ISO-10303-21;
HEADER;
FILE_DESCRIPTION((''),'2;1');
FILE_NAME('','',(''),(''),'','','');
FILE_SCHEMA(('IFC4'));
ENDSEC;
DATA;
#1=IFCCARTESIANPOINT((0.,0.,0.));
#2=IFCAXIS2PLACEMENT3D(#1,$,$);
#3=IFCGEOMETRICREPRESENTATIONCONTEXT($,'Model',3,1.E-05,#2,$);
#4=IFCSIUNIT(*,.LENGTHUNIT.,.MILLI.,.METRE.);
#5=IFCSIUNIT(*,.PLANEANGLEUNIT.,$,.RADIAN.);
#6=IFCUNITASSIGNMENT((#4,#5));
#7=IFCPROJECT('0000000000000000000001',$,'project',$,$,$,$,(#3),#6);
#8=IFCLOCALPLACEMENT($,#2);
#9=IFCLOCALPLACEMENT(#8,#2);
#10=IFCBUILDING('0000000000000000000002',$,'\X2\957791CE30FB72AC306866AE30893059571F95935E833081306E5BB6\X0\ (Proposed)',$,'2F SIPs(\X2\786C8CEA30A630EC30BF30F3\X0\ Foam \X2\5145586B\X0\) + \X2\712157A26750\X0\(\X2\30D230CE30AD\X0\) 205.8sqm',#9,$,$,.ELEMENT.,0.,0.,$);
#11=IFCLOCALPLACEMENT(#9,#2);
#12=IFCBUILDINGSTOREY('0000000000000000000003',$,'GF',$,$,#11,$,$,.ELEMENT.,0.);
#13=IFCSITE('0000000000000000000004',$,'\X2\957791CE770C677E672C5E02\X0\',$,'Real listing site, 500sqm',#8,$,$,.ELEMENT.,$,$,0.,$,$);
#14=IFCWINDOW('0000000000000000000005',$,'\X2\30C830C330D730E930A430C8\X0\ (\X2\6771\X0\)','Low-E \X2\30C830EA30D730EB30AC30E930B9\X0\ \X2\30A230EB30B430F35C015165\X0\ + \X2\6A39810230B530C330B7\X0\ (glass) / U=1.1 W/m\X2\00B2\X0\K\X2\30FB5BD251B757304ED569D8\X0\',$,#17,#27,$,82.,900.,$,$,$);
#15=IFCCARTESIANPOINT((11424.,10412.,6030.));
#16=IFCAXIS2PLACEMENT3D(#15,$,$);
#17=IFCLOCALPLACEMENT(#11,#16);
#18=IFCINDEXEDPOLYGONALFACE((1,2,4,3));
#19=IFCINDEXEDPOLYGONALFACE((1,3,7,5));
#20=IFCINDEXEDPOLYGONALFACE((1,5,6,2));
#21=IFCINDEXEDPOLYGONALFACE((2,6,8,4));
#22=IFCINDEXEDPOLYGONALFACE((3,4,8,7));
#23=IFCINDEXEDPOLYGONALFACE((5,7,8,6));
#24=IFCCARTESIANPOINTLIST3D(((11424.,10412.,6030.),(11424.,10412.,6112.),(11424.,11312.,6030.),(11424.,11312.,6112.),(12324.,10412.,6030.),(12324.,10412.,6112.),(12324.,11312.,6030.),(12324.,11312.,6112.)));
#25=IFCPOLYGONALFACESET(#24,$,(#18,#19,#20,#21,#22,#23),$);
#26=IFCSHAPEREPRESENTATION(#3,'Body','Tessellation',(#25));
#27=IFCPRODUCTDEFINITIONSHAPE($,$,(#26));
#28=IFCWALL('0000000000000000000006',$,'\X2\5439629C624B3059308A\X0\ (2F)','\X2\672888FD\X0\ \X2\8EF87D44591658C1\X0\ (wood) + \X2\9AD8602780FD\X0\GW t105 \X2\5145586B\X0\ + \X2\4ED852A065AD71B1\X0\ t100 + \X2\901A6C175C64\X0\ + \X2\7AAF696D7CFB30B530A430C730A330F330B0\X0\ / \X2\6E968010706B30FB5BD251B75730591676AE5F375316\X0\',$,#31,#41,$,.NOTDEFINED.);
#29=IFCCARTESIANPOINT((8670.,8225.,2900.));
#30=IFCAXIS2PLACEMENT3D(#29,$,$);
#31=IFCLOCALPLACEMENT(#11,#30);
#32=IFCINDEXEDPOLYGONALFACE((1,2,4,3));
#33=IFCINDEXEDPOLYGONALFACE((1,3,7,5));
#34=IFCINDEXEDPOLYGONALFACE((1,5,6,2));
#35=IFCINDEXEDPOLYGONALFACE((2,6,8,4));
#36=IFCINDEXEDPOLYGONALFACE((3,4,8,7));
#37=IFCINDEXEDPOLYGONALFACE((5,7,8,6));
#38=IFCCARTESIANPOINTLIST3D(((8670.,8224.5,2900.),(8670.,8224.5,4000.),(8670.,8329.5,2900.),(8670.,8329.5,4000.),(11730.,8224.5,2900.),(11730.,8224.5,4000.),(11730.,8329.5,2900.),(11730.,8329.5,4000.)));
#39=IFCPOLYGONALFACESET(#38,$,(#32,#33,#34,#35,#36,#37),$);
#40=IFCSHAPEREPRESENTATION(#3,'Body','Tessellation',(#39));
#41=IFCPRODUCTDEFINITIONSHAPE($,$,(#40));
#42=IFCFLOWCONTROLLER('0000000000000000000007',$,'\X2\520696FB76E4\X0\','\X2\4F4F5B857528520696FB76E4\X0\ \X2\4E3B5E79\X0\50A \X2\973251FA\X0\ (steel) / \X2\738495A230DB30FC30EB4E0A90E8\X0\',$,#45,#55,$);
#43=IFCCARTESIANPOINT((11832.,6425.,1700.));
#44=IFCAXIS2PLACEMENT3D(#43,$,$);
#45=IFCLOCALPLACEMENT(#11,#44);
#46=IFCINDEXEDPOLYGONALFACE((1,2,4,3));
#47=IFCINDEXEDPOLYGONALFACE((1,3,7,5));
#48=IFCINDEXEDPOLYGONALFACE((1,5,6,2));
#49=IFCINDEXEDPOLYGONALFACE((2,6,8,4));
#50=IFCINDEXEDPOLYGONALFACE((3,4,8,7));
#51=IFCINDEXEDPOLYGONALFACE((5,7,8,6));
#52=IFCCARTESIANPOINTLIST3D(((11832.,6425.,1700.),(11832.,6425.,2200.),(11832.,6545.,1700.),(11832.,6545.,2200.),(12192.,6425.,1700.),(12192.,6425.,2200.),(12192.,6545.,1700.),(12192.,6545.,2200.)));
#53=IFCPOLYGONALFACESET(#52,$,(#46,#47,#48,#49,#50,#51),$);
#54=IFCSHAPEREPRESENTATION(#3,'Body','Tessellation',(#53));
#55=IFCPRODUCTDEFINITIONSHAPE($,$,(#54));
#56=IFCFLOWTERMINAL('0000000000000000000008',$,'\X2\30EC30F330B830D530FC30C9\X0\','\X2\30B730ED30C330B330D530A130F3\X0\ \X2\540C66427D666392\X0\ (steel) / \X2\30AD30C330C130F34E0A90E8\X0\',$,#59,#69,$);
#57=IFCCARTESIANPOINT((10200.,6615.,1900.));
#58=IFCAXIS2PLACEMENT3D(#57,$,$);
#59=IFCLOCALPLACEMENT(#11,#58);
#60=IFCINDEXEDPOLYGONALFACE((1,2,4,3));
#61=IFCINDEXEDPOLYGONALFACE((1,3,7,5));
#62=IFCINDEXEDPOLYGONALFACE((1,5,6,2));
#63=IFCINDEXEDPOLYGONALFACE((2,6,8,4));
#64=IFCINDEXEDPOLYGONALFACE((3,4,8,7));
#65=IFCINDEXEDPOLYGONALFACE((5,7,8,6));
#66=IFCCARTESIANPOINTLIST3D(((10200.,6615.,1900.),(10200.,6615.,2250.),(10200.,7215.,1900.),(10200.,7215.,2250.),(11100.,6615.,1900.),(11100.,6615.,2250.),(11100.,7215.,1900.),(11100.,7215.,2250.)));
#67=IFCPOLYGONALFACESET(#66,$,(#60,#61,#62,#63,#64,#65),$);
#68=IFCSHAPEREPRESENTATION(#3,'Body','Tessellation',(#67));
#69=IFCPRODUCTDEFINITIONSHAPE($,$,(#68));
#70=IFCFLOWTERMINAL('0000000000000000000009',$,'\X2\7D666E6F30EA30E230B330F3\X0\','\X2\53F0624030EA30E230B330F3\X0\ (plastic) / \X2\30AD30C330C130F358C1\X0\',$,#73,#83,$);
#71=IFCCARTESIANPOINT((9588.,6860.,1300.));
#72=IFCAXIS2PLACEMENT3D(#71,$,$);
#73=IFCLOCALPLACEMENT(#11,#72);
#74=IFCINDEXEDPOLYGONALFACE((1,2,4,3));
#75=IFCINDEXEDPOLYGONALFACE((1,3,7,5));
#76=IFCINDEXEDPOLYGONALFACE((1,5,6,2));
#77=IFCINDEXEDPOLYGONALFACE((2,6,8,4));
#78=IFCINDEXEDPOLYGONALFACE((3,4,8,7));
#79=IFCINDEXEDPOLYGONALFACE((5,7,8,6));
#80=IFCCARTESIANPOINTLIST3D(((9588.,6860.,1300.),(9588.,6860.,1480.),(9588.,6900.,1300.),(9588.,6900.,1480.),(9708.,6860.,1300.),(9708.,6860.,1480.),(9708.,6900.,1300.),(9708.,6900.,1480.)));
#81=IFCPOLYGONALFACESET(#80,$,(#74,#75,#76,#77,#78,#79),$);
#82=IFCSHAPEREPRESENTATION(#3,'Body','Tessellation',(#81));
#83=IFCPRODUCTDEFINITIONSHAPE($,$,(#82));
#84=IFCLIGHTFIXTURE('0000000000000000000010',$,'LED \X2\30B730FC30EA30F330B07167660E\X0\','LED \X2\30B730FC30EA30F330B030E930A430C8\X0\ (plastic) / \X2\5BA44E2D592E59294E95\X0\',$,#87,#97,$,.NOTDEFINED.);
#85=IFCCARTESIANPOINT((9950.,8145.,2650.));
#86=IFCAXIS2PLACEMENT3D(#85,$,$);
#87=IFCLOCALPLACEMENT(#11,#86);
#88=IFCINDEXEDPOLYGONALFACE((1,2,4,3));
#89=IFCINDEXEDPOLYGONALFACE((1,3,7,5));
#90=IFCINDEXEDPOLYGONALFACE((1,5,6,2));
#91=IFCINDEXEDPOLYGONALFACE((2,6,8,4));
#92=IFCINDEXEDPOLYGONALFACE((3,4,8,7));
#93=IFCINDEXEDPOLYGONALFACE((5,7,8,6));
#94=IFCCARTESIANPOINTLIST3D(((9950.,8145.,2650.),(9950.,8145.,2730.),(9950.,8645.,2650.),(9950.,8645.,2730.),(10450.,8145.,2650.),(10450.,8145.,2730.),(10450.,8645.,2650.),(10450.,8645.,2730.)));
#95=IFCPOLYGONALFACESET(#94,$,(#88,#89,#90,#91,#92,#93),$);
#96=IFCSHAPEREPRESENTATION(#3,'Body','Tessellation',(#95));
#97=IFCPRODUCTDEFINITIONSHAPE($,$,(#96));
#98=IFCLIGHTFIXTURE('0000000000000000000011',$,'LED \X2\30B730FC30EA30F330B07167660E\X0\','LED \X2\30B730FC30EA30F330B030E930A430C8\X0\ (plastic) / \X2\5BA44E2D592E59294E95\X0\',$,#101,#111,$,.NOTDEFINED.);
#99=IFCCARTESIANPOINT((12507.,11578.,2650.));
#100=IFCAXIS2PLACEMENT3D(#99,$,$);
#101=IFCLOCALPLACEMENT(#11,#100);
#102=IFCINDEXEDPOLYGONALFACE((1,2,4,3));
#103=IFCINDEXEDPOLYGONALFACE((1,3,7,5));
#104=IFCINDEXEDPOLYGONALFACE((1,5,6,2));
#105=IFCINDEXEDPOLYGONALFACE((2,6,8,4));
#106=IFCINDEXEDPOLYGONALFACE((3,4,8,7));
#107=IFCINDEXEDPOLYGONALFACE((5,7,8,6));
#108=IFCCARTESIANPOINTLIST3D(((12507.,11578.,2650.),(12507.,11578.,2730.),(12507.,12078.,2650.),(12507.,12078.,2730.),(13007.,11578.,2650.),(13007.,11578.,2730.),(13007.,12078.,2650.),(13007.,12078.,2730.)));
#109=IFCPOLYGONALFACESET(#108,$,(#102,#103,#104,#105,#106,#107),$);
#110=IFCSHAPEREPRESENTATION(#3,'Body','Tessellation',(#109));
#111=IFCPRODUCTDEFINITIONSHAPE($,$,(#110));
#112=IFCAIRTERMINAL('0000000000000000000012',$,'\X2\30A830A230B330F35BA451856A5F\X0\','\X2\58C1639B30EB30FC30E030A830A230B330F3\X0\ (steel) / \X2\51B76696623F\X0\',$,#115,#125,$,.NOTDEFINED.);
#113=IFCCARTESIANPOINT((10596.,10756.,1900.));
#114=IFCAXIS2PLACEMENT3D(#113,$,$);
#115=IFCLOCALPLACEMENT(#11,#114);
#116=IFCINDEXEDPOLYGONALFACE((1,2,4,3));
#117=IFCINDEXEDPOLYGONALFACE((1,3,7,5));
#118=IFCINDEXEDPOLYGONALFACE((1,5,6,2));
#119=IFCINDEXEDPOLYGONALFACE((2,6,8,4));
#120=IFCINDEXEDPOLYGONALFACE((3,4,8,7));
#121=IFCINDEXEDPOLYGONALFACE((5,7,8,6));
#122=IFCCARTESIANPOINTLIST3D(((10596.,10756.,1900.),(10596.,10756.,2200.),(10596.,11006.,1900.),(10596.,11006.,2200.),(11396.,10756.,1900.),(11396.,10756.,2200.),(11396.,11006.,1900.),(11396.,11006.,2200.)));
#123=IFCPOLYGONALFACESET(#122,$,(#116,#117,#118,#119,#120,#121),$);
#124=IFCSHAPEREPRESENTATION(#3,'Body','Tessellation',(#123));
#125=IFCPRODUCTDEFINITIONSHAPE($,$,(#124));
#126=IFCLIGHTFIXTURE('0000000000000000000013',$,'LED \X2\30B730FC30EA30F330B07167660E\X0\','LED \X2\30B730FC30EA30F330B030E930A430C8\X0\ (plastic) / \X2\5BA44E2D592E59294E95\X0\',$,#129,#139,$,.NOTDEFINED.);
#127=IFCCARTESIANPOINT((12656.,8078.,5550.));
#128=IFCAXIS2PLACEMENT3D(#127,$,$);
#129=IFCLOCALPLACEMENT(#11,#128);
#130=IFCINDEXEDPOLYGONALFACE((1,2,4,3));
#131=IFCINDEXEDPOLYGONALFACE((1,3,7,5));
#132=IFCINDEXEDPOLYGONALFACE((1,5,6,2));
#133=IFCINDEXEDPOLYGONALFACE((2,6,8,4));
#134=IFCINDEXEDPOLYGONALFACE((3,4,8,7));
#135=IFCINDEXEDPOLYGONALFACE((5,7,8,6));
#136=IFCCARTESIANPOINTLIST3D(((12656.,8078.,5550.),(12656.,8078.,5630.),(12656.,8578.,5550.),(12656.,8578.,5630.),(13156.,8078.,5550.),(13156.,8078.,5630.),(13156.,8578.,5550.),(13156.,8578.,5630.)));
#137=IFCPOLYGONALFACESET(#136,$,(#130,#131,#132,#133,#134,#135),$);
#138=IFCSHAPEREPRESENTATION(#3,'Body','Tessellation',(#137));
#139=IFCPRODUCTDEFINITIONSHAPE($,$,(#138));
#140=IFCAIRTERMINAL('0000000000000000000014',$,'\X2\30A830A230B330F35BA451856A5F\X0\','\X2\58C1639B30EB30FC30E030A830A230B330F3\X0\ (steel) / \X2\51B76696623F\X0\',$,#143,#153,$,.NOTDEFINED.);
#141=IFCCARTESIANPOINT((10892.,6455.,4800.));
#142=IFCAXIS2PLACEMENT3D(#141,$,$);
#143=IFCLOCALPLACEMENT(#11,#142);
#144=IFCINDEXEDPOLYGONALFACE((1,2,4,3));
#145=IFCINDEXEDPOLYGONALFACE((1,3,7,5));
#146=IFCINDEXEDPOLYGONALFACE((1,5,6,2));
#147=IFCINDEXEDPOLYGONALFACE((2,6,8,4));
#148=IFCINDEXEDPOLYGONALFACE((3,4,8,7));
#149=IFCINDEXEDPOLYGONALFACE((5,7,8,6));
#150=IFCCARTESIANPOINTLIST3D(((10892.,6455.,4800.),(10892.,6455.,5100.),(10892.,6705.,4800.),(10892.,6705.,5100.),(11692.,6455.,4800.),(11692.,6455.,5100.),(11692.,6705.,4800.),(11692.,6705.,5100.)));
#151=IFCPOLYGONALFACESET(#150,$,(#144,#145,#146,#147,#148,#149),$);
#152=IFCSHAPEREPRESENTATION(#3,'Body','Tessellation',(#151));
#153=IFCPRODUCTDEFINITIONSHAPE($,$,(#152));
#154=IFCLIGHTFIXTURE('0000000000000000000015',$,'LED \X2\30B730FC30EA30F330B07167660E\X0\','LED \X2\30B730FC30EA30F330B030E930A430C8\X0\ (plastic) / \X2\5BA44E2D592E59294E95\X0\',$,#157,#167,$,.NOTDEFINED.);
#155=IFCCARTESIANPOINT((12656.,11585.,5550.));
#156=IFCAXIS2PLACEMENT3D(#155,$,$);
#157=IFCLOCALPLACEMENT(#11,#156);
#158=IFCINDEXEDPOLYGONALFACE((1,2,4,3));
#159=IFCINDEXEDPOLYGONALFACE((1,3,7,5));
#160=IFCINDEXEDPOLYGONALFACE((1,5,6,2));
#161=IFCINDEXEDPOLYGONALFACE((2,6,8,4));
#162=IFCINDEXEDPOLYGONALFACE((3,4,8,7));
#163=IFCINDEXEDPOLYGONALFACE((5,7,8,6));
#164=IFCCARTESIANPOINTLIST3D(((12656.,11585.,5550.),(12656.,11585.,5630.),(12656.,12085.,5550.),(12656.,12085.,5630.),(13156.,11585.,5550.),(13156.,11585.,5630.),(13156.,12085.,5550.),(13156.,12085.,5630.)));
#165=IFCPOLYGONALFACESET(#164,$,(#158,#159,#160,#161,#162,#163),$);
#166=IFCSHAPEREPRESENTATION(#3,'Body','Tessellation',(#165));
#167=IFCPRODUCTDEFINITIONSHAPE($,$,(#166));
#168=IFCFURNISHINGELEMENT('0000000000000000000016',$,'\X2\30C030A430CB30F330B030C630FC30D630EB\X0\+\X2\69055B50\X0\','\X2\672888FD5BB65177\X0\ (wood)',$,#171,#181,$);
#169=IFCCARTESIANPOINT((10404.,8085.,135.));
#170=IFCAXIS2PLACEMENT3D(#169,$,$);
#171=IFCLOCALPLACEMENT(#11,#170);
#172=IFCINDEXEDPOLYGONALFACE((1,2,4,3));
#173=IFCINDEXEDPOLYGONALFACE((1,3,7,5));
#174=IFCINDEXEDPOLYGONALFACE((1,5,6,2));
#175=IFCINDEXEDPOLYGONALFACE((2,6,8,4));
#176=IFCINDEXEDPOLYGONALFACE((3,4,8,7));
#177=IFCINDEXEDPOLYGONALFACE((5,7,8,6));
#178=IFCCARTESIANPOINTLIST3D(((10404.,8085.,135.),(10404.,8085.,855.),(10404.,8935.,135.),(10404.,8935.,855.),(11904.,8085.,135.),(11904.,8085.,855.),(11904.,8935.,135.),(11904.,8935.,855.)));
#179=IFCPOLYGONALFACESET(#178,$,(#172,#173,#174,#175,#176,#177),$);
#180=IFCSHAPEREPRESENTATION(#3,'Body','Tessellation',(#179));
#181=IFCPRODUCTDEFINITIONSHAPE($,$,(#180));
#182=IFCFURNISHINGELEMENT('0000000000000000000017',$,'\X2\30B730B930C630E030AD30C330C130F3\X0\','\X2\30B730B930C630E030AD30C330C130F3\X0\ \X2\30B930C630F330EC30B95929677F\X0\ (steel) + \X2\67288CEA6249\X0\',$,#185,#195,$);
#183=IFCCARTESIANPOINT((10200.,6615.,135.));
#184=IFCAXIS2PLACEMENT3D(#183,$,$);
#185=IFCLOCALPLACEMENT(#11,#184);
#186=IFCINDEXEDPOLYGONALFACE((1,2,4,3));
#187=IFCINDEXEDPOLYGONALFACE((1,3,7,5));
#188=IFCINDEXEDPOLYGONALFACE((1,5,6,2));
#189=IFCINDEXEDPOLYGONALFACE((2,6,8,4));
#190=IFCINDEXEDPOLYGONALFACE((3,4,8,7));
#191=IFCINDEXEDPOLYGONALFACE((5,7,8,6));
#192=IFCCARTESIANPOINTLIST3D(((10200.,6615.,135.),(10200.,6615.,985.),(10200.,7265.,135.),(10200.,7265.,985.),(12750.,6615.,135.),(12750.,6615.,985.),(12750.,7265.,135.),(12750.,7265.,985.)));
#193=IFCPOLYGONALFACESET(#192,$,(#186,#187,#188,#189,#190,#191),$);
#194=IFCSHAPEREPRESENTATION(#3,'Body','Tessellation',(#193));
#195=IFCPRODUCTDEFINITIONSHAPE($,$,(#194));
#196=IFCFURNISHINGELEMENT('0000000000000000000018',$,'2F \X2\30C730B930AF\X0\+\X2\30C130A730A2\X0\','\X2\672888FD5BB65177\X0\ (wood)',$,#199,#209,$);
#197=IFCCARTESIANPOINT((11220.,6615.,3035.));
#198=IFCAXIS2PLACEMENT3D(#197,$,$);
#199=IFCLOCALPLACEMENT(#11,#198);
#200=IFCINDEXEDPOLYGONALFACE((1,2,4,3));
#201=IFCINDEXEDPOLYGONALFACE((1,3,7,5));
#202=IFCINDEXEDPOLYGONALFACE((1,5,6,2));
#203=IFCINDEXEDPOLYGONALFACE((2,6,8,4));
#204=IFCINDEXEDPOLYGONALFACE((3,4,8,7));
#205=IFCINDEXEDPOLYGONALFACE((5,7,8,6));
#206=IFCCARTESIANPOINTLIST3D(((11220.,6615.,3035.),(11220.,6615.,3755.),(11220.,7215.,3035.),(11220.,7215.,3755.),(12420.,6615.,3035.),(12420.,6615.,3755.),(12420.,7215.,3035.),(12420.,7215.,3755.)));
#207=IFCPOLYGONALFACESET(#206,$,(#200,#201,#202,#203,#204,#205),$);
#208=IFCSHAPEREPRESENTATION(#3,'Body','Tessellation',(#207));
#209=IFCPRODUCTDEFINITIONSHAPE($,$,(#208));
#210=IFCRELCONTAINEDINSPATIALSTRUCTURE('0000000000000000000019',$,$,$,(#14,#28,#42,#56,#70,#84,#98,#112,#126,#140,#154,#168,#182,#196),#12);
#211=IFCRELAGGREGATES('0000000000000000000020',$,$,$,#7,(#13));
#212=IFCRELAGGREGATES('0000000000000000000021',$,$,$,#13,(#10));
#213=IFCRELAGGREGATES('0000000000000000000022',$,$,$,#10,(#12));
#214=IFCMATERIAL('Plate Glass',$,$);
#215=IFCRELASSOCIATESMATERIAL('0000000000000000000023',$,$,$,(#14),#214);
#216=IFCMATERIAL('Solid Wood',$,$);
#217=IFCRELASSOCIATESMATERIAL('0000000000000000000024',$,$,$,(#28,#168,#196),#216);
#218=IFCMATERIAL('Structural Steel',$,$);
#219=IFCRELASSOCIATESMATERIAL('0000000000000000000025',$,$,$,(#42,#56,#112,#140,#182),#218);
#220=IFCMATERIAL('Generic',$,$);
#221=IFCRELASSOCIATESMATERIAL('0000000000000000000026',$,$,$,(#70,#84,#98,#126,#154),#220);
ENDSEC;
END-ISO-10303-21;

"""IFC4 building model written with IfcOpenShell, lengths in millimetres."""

from ifc_helpers import new_model, si_unit, frame, frame_2d, origin, place, context, project, spatial, rectangle, extrude, material, element, save


model = new_model("IFC4")

# Units and contexts
model_context = context("Model", 3, precision=1e-05, world=origin())
ifc_project = project(units=[si_unit("LENGTHUNIT", "METRE", prefix="MILLI"), si_unit("PLANEANGLEUNIT", "RADIAN")], contexts=[model_context])

# Site, building, storey
site_placement = place(None, origin())
site = spatial("IfcSite", under=ifc_project, at=site_placement, Name="長野県松本市", ObjectType="Real listing site, 500sqm", CompositionType="ELEMENT", RefElevation=0.0)
building_placement = place(site_placement, origin())
building = spatial("IfcBuilding", under=site, at=building_placement, Name="長野・犬と暮らす土間広めの家 (Proposed)", ObjectType="2F SIPs(硬質ウレタン Foam 充填) + 無垢材(ヒノキ) 205.8sqm", CompositionType="ELEMENT", ElevationOfRefHeight=0.0, ElevationOfTerrain=0.0)
storey_placement = place(building_placement, origin())
storey = spatial("IfcBuildingStorey", under=building, at=storey_placement, Name="GF", CompositionType="ELEMENT", Elevation=0.0)

# Shared definitions
ifc_material_1 = material(Name="Solid Wood")

# Window
ifc_material_2 = material(Name="Plate Glass")
window_placement = place(storey_placement, frame((11424.0, 10412.0, 6030.0)))
element("IfcWindow", 1, at=window_placement, inside=storey, material=ifc_material_2, Name="トップライト (東)", Description="Low-E トリプルガラス アルゴン封入 + 樹脂サッシ (glass) / U=1.1 W/m²K・寒冷地仕様", OverallHeight=82.0, OverallWidth=900.0, context=model_context, shape_type="SweptSolid", body=[
    extrude(rectangle(XDim=900.0, YDim=900.0, at=frame_2d((450.0, 450.0))), frame((11424.0, 10412.0, 6030.0)), (0.0, 0.0, 1.0), 82.0),
])

# Wall
wall_1_placement = place(storey_placement, frame((8670.0, 8225.0, 2900.0)))
element("IfcWall", 2, at=wall_1_placement, inside=storey, material=ifc_material_1, Name="吹抜手すり (2F)", Description="木製 軸組外壁 (wood) + 高性能GW t105 充填 + 付加断熱 t100 + 通気層 + 窯業系サイディング / 準耐火・寒冷地外皮強化", PredefinedType="NOTDEFINED", context=model_context, shape_type="SweptSolid", body=[
    extrude(rectangle(XDim=3060.0, YDim=105.0, at=frame_2d((1530.0, 52.0))), frame((8670.0, 8225.0, 2900.0)), (0.0, 0.0, 1.0), 1100.0),
])

# Flow controller
ifc_material_3 = material(Name="Structural Steel")
flow_controller_placement = place(storey_placement, frame((11832.0, 6425.0, 1700.0)))
element("IfcFlowController", 3, at=flow_controller_placement, inside=storey, material=ifc_material_3, Name="分電盤", Description="住宅用分電盤 主幹50A 露出 (steel) / 玄関ホール上部", context=model_context, shape_type="SweptSolid", body=[
    extrude(rectangle(XDim=360.0, YDim=120.0, at=frame_2d((180.0, 60.0))), frame((11832.0, 6425.0, 1700.0)), (0.0, 0.0, 1.0), 500.0),
])

# Flow terminals
flow_terminal_1_placement = place(storey_placement, frame((10200.0, 6615.0, 1900.0)))
element("IfcFlowTerminal", 4, at=flow_terminal_1_placement, inside=storey, material=ifc_material_3, Name="レンジフード", Description="シロッコファン 同時給排 (steel) / キッチン上部", context=model_context, shape_type="SweptSolid", body=[
    extrude(rectangle(XDim=900.0, YDim=600.0, at=frame_2d((450.0, 300.0))), frame((10200.0, 6615.0, 1900.0)), (0.0, 0.0, 1.0), 350.0),
])
ifc_material_4 = material(Name="Generic")
flow_terminal_2_placement = place(storey_placement, frame((9588.0, 6860.0, 1300.0)))
element("IfcFlowTerminal", 5, at=flow_terminal_2_placement, inside=storey, material=ifc_material_4, Name="給湯リモコン", Description="台所リモコン (plastic) / キッチン壁", context=model_context, shape_type="SweptSolid", body=[
    extrude(rectangle(XDim=120.0, YDim=40.0, at=frame_2d((60.0, 20.0))), frame((9588.0, 6860.0, 1300.0)), (0.0, 0.0, 1.0), 180.0),
])

# Light fixtures
light_fixture_1_placement = place(storey_placement, frame((9950.0, 8145.0, 2650.0)))
element("IfcLightFixture", 6, at=light_fixture_1_placement, inside=storey, material=ifc_material_4, Name="LED シーリング照明", Description="LED シーリングライト (plastic) / 室中央天井", PredefinedType="NOTDEFINED", context=model_context, shape_type="SweptSolid", body=[
    extrude(rectangle(XDim=500.0, YDim=500.0, at=frame_2d((250.0, 250.0))), frame((9950.0, 8145.0, 2650.0)), (0.0, 0.0, 1.0), 80.0),
])
light_fixture_2_placement = place(storey_placement, frame((12507.0, 11578.0, 2650.0)))
element("IfcLightFixture", 7, at=light_fixture_2_placement, inside=storey, material=ifc_material_4, Name="LED シーリング照明", Description="LED シーリングライト (plastic) / 室中央天井", PredefinedType="NOTDEFINED", context=model_context, shape_type="SweptSolid", body=[
    extrude(rectangle(XDim=500.0, YDim=500.0, at=frame_2d((250.0, 250.0))), frame((12507.0, 11578.0, 2650.0)), (0.0, 0.0, 1.0), 80.0),
])

# Air terminal
air_terminal_1_placement = place(storey_placement, frame((10596.0, 10756.0, 1900.0)))
element("IfcAirTerminal", 8, at=air_terminal_1_placement, inside=storey, material=ifc_material_3, Name="エアコン室内機", Description="壁掛ルームエアコン (steel) / 冷暖房", PredefinedType="NOTDEFINED", context=model_context, shape_type="SweptSolid", body=[
    extrude(rectangle(XDim=800.0, YDim=250.0, at=frame_2d((400.0, 125.0))), frame((10596.0, 10756.0, 1900.0)), (0.0, 0.0, 1.0), 300.0),
])

# Light fixture
light_fixture_3_placement = place(storey_placement, frame((12656.0, 8078.0, 5550.0)))
element("IfcLightFixture", 9, at=light_fixture_3_placement, inside=storey, material=ifc_material_4, Name="LED シーリング照明", Description="LED シーリングライト (plastic) / 室中央天井", PredefinedType="NOTDEFINED", context=model_context, shape_type="SweptSolid", body=[
    extrude(rectangle(XDim=500.0, YDim=500.0, at=frame_2d((250.0, 250.0))), frame((12656.0, 8078.0, 5550.0)), (0.0, 0.0, 1.0), 80.0),
])

# Air terminal
air_terminal_2_placement = place(storey_placement, frame((10892.0, 6455.0, 4800.0)))
element("IfcAirTerminal", 10, at=air_terminal_2_placement, inside=storey, material=ifc_material_3, Name="エアコン室内機", Description="壁掛ルームエアコン (steel) / 冷暖房", PredefinedType="NOTDEFINED", context=model_context, shape_type="SweptSolid", body=[
    extrude(rectangle(XDim=800.0, YDim=250.0, at=frame_2d((400.0, 125.0))), frame((10892.0, 6455.0, 4800.0)), (0.0, 0.0, 1.0), 300.0),
])

# Light fixture
light_fixture_4_placement = place(storey_placement, frame((12656.0, 11585.0, 5550.0)))
element("IfcLightFixture", 11, at=light_fixture_4_placement, inside=storey, material=ifc_material_4, Name="LED シーリング照明", Description="LED シーリングライト (plastic) / 室中央天井", PredefinedType="NOTDEFINED", context=model_context, shape_type="SweptSolid", body=[
    extrude(rectangle(XDim=500.0, YDim=500.0, at=frame_2d((250.0, 250.0))), frame((12656.0, 11585.0, 5550.0)), (0.0, 0.0, 1.0), 80.0),
])

# Furnishing elements
furnishing_1_placement = place(storey_placement, frame((10404.0, 8085.0, 135.0)))
element("IfcFurnishingElement", 12, at=furnishing_1_placement, inside=storey, material=ifc_material_1, Name="ダイニングテーブル+椅子", Description="木製家具 (wood)", context=model_context, shape_type="SweptSolid", body=[
    extrude(rectangle(XDim=1500.0, YDim=850.0, at=frame_2d((750.0, 425.0))), frame((10404.0, 8085.0, 135.0)), (0.0, 0.0, 1.0), 720.0),
])
furnishing_2_placement = place(storey_placement, frame((10200.0, 6615.0, 135.0)))
element("IfcFurnishingElement", 13, at=furnishing_2_placement, inside=storey, material=ifc_material_3, Name="システムキッチン", Description="システムキッチン ステンレス天板 (steel) + 木質扉", context=model_context, shape_type="SweptSolid", body=[
    extrude(rectangle(XDim=2550.0, YDim=650.0, at=frame_2d((1275.0, 325.0))), frame((10200.0, 6615.0, 135.0)), (0.0, 0.0, 1.0), 850.0),
])
furnishing_3_placement = place(storey_placement, frame((11220.0, 6615.0, 3035.0)))
element("IfcFurnishingElement", 14, at=furnishing_3_placement, inside=storey, material=ifc_material_1, Name="2F デスク+チェア", Description="木製家具 (wood)", context=model_context, shape_type="SweptSolid", body=[
    extrude(rectangle(XDim=1200.0, YDim=600.0, at=frame_2d((600.0, 300.0))), frame((11220.0, 6615.0, 3035.0)), (0.0, 0.0, 1.0), 720.0),
])

save(model, "model.ifc")
